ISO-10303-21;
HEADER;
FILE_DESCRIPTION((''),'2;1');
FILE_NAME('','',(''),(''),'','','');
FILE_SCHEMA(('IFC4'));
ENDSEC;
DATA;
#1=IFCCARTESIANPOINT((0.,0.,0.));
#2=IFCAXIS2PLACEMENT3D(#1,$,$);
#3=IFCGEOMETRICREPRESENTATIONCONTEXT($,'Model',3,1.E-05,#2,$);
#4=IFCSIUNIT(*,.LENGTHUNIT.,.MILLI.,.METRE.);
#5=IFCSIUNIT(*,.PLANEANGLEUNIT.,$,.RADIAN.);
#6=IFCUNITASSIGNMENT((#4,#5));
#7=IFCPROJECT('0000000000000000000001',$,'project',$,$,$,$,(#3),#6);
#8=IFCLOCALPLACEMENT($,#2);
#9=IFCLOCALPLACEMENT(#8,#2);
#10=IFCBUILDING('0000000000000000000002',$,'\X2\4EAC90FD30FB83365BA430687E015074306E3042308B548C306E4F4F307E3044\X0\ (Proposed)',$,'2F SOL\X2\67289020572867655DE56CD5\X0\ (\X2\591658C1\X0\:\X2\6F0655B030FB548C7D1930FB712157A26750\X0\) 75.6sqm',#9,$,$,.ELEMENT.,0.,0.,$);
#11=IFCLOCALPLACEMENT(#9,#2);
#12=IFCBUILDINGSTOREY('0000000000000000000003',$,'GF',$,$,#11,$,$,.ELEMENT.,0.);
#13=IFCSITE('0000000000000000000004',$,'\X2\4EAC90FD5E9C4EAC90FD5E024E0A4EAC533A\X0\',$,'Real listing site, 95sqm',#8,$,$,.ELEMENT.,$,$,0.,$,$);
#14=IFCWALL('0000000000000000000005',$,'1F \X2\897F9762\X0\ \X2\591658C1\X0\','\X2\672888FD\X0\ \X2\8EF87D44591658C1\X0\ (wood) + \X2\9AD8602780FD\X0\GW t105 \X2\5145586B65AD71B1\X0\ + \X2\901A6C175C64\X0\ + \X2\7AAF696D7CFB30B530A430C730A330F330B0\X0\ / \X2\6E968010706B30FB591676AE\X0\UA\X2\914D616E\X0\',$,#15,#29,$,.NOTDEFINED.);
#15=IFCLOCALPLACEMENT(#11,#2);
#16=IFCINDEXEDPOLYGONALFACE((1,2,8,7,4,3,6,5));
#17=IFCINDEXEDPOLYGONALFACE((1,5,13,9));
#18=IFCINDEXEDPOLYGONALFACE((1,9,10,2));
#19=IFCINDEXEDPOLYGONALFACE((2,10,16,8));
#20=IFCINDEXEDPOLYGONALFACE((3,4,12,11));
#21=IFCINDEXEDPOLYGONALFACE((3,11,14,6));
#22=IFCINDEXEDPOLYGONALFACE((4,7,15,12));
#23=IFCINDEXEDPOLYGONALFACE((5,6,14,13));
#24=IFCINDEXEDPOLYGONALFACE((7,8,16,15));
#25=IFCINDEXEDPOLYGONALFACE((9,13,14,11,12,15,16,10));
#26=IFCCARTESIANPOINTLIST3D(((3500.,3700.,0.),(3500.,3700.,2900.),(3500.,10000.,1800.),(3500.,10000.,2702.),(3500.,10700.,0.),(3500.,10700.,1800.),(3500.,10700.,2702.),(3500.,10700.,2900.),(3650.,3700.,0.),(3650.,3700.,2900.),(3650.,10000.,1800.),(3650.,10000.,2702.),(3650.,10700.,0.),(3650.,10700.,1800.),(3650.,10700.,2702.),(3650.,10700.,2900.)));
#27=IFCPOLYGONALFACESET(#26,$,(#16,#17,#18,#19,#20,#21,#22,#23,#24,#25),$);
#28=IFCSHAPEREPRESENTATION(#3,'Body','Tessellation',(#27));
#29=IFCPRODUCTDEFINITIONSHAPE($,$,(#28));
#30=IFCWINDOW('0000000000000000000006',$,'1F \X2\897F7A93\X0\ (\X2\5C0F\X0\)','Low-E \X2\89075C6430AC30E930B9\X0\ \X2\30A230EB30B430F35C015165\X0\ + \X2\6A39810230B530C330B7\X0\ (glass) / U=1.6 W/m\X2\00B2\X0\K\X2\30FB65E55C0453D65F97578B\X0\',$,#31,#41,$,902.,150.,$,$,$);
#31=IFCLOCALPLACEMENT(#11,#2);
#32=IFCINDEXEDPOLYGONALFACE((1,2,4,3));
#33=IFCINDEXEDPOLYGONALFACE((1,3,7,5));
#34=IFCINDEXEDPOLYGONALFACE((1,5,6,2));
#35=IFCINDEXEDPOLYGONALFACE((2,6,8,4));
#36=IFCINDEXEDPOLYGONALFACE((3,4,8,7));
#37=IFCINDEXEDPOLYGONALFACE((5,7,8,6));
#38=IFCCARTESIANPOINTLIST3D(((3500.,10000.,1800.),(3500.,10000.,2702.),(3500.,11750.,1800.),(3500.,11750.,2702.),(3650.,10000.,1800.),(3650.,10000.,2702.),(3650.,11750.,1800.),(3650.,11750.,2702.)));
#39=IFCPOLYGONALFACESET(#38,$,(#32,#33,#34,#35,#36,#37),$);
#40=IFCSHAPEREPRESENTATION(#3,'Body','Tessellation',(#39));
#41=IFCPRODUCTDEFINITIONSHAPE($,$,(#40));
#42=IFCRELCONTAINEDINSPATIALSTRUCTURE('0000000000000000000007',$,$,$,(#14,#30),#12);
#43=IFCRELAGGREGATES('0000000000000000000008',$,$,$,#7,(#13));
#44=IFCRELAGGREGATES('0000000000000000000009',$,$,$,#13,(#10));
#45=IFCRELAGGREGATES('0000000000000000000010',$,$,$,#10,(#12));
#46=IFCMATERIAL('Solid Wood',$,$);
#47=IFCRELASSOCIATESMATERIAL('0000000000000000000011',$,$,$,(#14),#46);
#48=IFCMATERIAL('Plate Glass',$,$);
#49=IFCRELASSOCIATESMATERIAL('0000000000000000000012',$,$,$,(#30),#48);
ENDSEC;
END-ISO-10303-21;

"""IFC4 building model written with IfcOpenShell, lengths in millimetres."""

from ifc_helpers import new_model, si_unit, frame, frame_2d, origin, place, context, project, spatial, rectangle, extrude, material, element, fill, save


model = new_model("IFC4")

# Units and contexts
model_context = context("Model", 3, precision=1e-05, world=origin())
ifc_project = project(units=[si_unit("LENGTHUNIT", "METRE", prefix="MILLI"), si_unit("PLANEANGLEUNIT", "RADIAN")], contexts=[model_context])

# Site, building, storey
site_placement = place(None, origin())
site = spatial("IfcSite", under=ifc_project, at=site_placement, Name="京都府京都市上京区", ObjectType="Real listing site, 95sqm", CompositionType="ELEMENT", RefElevation=0.0)
building_placement = place(site_placement, origin())
building = spatial("IfcBuilding", under=site, at=building_placement, Name="京都・茶室と縁側のある和の住まい (Proposed)", ObjectType="2F SOL木造在来工法 (外壁:漆喰・和紙・無垢材) 75.6sqm", CompositionType="ELEMENT", ElevationOfRefHeight=0.0, ElevationOfTerrain=0.0)
storey_placement = place(building_placement, origin())
storey = spatial("IfcBuildingStorey", under=building, at=storey_placement, Name="GF", CompositionType="ELEMENT", Elevation=0.0)

# Shared definitions
ifc_material_1 = material(Name="Solid Wood")

# Shared definitions
ifc_material_2 = material(Name="Plate Glass")

# Wall, opening, window
wall_1_placement = place(storey_placement, frame((1750.0, 1850.0, 0.0)))
wall_1 = element("IfcWall", 1, at=wall_1_placement, inside=storey, material=ifc_material_1, Name="1F 西面 外壁", Description="木製 軸組外壁 (wood) + 高性能GW t105 充填断熱 + 通気層 + 窯業系サイディング / 準耐火・外皮UA配慮", PredefinedType="NOTDEFINED", context=model_context, shape_type="SweptSolid", body=[
    extrude(rectangle(XDim=150.0, YDim=7000.0, at=frame_2d((75.0, 3500.0))), frame((1750.0, 1850.0, 0.0)), (0.0, 0.0, 1.0), 2900.0),
])
opening_1_placement = place(storey_placement, frame((1750.0, 5000.0, 900.0)))
opening_1 = element("IfcOpeningElement", 2, at=opening_1_placement, cuts=wall_1, PredefinedType="NOTDEFINED", context=model_context, shape_type="SweptSolid", body=[
    extrude(rectangle(XDim=150.0, YDim=1750.0, at=frame_2d((75.0, 875.0))), frame((1750.0, 5000.0, 900.0)), (0.0, 0.0, 1.0), 902.0),
])
window_1_placement = place(storey_placement, frame((1750.0, 5000.0, 900.0)))
window_1 = element("IfcWindow", 3, at=window_1_placement, inside=storey, material=ifc_material_2, Name="1F 西窓 (小)", Description="Low-E 複層ガラス アルゴン封入 + 樹脂サッシ (glass) / U=1.6 W/m²K・日射取得型", OverallHeight=902.0, OverallWidth=150.0, context=model_context, shape_type="SweptSolid", body=[
    extrude(rectangle(XDim=150.0, YDim=1750.0, at=frame_2d((75.0, 875.0))), frame((1750.0, 5000.0, 900.0)), (0.0, 0.0, 1.0), 902.0),
])
fill(opening_1, window_1)

save(model, "model.ifc")
